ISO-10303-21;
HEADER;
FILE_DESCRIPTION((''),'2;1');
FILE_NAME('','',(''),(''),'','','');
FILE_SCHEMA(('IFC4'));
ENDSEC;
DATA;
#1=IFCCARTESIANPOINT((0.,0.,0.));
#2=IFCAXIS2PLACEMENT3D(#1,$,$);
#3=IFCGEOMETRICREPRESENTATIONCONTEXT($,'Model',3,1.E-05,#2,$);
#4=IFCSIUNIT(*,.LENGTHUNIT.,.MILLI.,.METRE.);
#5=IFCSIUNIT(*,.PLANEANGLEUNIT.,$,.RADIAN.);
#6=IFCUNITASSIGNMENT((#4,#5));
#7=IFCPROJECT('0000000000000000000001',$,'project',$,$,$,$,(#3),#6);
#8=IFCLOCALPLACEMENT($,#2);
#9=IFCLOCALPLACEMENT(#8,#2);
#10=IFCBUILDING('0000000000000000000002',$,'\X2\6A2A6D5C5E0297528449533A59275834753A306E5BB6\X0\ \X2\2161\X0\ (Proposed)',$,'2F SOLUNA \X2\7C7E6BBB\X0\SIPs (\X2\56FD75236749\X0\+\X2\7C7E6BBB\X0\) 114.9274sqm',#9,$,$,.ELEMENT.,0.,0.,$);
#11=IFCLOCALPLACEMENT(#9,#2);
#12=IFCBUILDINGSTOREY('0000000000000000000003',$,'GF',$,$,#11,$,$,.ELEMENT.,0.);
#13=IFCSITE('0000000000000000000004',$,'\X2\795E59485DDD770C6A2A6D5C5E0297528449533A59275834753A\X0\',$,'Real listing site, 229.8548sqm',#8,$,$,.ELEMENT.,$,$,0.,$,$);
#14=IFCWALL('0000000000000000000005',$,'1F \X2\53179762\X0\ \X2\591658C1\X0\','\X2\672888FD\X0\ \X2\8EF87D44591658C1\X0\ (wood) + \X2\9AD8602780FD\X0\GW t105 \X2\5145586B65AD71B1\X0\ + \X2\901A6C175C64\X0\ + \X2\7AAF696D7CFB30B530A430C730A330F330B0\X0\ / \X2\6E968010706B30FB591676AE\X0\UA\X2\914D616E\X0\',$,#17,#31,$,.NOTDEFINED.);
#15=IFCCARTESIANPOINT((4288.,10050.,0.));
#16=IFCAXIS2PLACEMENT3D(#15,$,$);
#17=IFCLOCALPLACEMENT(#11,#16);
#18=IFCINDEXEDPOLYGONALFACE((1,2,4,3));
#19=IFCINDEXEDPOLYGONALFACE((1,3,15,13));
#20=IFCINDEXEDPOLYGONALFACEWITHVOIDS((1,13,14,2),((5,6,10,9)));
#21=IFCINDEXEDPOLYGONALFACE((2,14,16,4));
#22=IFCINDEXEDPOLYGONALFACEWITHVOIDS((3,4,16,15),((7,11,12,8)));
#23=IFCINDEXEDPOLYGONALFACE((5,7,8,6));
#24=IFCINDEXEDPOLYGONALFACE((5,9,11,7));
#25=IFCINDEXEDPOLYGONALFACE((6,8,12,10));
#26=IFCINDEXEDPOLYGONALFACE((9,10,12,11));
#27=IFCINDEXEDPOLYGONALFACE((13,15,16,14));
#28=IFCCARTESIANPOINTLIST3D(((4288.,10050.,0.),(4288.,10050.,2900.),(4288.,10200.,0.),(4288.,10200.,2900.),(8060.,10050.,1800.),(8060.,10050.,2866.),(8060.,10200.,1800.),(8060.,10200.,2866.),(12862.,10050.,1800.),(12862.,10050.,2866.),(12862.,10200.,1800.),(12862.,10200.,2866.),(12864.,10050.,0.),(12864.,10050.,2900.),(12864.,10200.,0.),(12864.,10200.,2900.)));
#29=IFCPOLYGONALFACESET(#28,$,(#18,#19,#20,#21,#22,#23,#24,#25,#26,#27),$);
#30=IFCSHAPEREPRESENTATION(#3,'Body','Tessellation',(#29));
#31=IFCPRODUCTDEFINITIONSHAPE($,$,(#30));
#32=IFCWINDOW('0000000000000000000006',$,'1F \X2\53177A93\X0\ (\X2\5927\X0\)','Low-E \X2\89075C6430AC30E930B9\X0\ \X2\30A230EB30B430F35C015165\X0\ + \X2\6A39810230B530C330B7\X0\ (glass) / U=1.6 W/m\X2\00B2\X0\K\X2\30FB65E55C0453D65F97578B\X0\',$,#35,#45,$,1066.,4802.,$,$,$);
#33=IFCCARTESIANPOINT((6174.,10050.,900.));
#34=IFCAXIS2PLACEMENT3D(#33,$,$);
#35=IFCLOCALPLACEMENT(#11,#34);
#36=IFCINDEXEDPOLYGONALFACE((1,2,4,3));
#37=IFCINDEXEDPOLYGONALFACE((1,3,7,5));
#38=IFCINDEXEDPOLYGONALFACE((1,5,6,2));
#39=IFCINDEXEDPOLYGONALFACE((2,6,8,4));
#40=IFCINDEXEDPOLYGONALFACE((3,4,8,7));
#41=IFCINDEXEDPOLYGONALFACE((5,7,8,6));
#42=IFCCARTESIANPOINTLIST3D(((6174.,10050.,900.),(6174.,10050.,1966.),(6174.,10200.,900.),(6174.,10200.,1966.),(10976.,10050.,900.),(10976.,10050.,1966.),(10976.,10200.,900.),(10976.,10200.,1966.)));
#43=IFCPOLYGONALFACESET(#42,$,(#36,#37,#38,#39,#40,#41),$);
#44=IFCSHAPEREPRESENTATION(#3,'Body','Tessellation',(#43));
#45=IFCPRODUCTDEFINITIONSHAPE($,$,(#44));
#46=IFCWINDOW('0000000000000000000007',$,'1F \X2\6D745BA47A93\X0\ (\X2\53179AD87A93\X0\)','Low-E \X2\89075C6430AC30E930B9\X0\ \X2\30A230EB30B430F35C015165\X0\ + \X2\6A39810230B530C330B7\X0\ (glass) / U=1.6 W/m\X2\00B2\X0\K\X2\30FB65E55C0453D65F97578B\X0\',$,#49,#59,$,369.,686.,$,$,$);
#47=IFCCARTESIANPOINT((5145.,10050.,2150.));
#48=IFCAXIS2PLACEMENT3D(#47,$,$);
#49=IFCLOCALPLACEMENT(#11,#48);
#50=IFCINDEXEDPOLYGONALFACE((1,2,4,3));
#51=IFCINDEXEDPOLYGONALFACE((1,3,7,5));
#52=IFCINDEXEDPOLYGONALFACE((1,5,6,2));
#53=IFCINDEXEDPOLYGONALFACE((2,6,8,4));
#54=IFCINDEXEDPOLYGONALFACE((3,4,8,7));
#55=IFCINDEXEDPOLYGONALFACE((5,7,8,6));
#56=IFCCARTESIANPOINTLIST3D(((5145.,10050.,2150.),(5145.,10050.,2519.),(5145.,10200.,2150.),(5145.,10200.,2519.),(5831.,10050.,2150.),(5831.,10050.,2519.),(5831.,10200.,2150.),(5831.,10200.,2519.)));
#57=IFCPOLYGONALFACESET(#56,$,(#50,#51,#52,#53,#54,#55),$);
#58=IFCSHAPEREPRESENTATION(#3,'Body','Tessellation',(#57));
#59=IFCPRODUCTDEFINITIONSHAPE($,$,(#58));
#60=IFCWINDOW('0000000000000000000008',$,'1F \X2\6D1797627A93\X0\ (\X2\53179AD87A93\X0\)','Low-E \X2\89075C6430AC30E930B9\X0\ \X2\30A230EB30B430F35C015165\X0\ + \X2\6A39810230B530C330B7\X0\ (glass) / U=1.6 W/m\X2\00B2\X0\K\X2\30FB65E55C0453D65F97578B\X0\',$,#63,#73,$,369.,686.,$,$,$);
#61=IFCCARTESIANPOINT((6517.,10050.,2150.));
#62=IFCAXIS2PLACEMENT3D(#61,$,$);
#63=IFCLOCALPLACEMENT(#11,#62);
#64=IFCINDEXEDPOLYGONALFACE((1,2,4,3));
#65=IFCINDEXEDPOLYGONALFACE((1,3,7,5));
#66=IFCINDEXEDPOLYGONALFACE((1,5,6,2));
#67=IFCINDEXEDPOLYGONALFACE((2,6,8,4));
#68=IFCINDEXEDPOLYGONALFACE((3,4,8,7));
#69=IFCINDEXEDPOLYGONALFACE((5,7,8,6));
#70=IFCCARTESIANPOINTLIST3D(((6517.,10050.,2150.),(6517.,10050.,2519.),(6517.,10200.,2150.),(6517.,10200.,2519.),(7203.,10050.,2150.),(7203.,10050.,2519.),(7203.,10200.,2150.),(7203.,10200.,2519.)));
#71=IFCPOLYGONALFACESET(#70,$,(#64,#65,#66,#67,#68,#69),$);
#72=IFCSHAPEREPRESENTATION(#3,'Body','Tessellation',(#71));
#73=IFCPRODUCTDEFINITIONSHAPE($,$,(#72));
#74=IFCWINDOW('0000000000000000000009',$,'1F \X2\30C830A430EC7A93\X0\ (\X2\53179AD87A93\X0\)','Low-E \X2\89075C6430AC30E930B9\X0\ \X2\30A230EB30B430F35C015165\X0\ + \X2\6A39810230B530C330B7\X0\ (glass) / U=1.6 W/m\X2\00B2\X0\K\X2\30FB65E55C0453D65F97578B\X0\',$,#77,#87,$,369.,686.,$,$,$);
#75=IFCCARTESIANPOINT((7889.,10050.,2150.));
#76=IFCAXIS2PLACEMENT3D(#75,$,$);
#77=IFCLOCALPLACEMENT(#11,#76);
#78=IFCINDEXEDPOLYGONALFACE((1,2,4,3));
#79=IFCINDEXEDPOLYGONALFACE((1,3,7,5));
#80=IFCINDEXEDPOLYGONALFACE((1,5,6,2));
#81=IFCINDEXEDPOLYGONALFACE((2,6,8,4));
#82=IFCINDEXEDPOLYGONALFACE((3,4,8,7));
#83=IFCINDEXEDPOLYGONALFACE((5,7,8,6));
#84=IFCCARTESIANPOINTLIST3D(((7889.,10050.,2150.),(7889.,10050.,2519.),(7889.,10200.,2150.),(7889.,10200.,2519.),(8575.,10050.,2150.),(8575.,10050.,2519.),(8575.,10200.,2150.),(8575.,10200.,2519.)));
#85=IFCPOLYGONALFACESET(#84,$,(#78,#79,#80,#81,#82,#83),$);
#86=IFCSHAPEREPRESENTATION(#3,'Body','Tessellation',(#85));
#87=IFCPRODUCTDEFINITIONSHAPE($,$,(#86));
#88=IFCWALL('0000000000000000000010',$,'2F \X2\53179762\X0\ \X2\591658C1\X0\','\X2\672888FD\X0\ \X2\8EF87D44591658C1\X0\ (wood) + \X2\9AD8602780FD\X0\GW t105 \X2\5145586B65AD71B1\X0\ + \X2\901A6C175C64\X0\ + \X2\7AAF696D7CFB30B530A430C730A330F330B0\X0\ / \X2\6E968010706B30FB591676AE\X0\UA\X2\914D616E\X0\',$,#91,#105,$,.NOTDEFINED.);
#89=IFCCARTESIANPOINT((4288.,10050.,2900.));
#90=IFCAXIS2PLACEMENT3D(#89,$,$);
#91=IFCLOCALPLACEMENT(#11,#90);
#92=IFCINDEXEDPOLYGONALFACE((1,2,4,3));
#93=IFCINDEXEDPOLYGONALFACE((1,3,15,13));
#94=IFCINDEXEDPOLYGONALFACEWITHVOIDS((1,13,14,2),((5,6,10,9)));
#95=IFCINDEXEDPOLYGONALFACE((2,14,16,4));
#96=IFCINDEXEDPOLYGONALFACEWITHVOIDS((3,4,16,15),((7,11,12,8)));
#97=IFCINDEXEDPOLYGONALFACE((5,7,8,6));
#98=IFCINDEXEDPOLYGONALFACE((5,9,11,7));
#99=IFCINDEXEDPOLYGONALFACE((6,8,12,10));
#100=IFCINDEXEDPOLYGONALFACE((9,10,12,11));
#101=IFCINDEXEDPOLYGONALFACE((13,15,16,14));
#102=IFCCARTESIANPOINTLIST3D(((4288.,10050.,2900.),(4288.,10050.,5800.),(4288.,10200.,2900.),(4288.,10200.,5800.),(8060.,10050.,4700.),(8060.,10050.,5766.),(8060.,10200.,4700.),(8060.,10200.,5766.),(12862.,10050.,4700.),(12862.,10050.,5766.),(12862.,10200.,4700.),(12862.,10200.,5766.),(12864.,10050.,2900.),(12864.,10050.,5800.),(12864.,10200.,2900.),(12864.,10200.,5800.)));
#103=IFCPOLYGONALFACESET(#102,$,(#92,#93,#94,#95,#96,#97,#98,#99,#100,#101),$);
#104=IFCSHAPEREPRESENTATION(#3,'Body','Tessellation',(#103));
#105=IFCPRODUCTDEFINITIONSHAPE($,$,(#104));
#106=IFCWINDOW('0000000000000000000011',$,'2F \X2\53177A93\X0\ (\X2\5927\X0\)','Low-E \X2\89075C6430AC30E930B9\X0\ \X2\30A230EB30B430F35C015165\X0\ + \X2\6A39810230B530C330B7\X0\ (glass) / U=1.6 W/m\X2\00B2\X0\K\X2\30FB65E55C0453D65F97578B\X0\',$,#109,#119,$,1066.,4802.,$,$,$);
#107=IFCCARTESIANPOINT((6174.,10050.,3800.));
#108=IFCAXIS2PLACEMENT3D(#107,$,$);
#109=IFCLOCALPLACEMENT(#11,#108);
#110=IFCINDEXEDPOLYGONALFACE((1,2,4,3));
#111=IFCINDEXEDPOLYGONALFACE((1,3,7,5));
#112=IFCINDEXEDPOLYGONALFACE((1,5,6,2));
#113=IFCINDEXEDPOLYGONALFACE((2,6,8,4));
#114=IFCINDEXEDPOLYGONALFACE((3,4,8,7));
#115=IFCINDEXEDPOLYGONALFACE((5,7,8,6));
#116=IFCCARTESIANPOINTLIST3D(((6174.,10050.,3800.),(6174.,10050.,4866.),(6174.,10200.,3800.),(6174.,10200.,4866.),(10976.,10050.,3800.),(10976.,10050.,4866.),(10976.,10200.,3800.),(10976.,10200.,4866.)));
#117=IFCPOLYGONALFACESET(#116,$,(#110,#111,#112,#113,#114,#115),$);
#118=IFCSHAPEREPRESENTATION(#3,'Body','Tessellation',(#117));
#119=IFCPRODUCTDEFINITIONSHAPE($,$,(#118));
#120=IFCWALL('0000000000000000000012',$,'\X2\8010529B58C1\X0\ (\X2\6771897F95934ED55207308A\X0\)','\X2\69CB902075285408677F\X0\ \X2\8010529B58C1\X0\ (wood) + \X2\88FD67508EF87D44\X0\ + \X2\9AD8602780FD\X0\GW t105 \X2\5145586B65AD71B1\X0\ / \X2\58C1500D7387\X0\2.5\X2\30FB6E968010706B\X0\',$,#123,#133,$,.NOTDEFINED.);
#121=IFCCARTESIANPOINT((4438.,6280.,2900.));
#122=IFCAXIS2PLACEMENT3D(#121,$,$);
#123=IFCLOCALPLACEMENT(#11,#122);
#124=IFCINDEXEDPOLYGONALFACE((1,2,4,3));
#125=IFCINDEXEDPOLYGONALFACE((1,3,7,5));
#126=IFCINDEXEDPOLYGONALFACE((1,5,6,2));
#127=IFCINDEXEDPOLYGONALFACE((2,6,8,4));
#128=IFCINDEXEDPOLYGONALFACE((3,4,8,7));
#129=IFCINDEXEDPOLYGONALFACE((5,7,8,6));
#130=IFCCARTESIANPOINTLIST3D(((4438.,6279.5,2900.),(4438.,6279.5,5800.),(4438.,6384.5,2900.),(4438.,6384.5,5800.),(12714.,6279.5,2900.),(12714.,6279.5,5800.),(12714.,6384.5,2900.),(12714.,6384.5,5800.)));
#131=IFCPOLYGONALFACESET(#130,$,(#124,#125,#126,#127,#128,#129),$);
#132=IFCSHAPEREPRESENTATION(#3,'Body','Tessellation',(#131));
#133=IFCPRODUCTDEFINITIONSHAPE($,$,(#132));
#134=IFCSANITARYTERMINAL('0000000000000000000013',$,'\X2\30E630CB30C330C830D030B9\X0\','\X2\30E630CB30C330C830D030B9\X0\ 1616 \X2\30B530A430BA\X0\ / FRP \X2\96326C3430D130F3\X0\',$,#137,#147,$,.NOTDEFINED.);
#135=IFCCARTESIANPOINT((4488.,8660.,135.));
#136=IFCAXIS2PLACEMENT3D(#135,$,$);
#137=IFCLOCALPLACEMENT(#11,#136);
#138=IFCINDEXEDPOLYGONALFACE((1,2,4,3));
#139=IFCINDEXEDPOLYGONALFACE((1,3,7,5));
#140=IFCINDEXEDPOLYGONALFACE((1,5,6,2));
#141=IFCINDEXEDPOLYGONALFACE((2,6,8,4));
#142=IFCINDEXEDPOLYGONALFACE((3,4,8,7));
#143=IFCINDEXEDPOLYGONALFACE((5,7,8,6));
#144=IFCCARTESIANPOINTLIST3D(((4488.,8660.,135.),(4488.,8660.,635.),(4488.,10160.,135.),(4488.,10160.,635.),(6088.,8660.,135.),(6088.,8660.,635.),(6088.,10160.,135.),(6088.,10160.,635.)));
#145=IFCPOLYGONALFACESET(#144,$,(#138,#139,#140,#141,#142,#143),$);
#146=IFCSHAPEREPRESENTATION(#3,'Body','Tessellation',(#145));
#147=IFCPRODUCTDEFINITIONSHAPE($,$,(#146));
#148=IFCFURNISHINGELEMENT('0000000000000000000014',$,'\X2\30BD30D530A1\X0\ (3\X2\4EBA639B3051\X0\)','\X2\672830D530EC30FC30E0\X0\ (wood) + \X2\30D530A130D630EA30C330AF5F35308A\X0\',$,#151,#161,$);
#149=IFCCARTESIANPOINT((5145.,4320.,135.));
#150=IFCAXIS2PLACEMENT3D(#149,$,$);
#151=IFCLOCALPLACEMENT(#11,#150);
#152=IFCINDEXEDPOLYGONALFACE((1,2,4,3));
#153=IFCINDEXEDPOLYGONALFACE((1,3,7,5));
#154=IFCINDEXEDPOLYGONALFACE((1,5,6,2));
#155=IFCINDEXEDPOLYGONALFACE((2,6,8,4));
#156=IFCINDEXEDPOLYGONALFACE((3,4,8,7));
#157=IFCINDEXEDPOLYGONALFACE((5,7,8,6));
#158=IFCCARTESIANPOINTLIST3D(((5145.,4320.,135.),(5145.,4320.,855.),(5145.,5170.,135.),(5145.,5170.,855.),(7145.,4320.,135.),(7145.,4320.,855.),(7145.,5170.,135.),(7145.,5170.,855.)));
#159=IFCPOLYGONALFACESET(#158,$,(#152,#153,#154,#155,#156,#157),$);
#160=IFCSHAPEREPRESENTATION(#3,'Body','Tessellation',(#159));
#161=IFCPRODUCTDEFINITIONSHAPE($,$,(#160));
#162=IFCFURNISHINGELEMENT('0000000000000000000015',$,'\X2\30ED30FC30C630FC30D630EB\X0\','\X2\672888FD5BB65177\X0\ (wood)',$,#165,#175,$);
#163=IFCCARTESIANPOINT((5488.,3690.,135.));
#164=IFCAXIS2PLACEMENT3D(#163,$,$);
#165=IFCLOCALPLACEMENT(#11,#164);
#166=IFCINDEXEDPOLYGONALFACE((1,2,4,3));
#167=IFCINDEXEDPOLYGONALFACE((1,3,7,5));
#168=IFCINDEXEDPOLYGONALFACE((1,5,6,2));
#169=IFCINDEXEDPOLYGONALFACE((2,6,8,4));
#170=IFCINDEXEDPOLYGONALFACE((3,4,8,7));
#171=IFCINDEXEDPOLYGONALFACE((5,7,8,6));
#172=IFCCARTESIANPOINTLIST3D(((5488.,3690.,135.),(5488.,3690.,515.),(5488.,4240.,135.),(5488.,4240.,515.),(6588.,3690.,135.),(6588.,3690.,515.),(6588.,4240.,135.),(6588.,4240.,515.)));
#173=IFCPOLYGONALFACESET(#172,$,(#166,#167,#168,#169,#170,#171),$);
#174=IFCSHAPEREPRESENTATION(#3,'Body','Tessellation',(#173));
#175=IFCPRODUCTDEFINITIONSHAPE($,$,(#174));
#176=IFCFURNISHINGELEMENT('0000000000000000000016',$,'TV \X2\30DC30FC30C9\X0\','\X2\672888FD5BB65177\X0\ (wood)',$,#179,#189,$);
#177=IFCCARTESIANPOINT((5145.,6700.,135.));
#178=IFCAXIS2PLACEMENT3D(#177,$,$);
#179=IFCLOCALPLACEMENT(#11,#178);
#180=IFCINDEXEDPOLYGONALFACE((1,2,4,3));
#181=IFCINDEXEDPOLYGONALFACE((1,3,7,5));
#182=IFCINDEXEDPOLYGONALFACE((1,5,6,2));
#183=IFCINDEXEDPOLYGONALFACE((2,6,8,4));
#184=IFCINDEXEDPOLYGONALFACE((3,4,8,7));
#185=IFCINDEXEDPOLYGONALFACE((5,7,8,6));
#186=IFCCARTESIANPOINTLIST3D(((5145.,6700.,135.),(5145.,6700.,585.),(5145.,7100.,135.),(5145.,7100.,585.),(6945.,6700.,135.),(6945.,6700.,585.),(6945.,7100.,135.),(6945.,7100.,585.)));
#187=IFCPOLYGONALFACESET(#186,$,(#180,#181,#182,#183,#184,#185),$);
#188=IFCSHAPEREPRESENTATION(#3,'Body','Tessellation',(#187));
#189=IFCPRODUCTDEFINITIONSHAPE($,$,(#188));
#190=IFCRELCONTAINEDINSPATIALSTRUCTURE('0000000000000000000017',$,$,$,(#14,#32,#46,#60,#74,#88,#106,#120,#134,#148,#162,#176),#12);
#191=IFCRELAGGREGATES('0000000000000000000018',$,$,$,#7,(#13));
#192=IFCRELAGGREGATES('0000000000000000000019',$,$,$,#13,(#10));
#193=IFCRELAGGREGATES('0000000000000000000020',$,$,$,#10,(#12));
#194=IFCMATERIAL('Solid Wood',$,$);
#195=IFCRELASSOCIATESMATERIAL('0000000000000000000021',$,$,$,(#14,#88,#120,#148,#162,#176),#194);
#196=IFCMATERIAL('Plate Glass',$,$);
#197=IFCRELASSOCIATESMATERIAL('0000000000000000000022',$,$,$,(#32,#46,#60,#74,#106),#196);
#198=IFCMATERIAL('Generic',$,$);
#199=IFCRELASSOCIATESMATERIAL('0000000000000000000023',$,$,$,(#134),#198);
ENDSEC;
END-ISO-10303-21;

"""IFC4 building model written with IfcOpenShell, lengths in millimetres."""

from ifc_helpers import new_model, si_unit, frame, frame_2d, origin, place, context, project, spatial, rectangle, extrude, material, element, fill, save


model = new_model("IFC4")

# Units and contexts
model_context = context("Model", 3, precision=1e-05, world=origin())
ifc_project = project(units=[si_unit("LENGTHUNIT", "METRE", prefix="MILLI"), si_unit("PLANEANGLEUNIT", "RADIAN")], contexts=[model_context])

# Site, building, storey
site_placement = place(None, origin())
site = spatial("IfcSite", under=ifc_project, at=site_placement, Name="神奈川県横浜市青葉区大場町", ObjectType="Real listing site, 229.8548sqm", CompositionType="ELEMENT", RefElevation=0.0)
building_placement = place(site_placement, origin())
building = spatial("IfcBuilding", under=site, at=building_placement, Name="横浜市青葉区大場町の家 Ⅱ (Proposed)", ObjectType="2F SOLUNA 籾殻SIPs (国産杉+籾殻) 114.9274sqm", CompositionType="ELEMENT", ElevationOfRefHeight=0.0, ElevationOfTerrain=0.0)
storey_placement = place(building_placement, origin())
storey = spatial("IfcBuildingStorey", under=building, at=storey_placement, Name="GF", CompositionType="ELEMENT", Elevation=0.0)

# Wall, openings, windows
ifc_material_1 = material(Name="Solid Wood")
wall_1_placement = place(storey_placement, frame((4288.0, 10050.0, 0.0)))
wall_1 = element("IfcWall", 1, at=wall_1_placement, inside=storey, material=ifc_material_1, Name="1F 北面 外壁", Description="木製 軸組外壁 (wood) + 高性能GW t105 充填断熱 + 通気層 + 窯業系サイディング / 準耐火・外皮UA配慮", PredefinedType="NOTDEFINED", context=model_context, shape_type="SweptSolid", body=[
    extrude(rectangle(XDim=8576.0, YDim=150.0, at=frame_2d((4288.0, 75.0))), frame((4288.0, 10050.0, 0.0)), (0.0, 0.0, 1.0), 2900.0),
])
opening_1_placement = place(storey_placement, frame((6174.0, 10050.0, 900.0)))
opening_1 = element("IfcOpeningElement", 2, at=opening_1_placement, cuts=wall_1, PredefinedType="NOTDEFINED", context=model_context, shape_type="SweptSolid", body=[
    extrude(rectangle(XDim=4802.0, YDim=150.0, at=frame_2d((2401.0, 75.0))), frame((6174.0, 10050.0, 900.0)), (0.0, 0.0, 1.0), 1066.0),
])
opening_2_placement = place(storey_placement, frame((5145.0, 10050.0, 2150.0)))
opening_2 = element("IfcOpeningElement", 3, at=opening_2_placement, cuts=wall_1, PredefinedType="NOTDEFINED", context=model_context, shape_type="SweptSolid", body=[
    extrude(rectangle(XDim=686.0, YDim=150.0, at=frame_2d((343.0, 75.0))), frame((5145.0, 10050.0, 2150.0)), (0.0, 0.0, 1.0), 369.0),
])
opening_3_placement = place(storey_placement, frame((6517.0, 10050.0, 2150.0)))
opening_3 = element("IfcOpeningElement", 4, at=opening_3_placement, cuts=wall_1, PredefinedType="NOTDEFINED", context=model_context, shape_type="SweptSolid", body=[
    extrude(rectangle(XDim=686.0, YDim=150.0, at=frame_2d((343.0, 75.0))), frame((6517.0, 10050.0, 2150.0)), (0.0, 0.0, 1.0), 369.0),
])
opening_4_placement = place(storey_placement, frame((7889.0, 10050.0, 2150.0)))
opening_4 = element("IfcOpeningElement", 5, at=opening_4_placement, cuts=wall_1, PredefinedType="NOTDEFINED", context=model_context, shape_type="SweptSolid", body=[
    extrude(rectangle(XDim=686.0, YDim=150.0, at=frame_2d((343.0, 75.0))), frame((7889.0, 10050.0, 2150.0)), (0.0, 0.0, 1.0), 369.0),
])
ifc_material_2 = material(Name="Plate Glass")
window_1_placement = place(storey_placement, frame((6174.0, 10050.0, 900.0)))
window_1 = element("IfcWindow", 6, at=window_1_placement, inside=storey, material=ifc_material_2, Name="1F 北窓 (大)", Description="Low-E 複層ガラス アルゴン封入 + 樹脂サッシ (glass) / U=1.6 W/m²K・日射取得型", OverallHeight=1066.0, OverallWidth=4802.0, context=model_context, shape_type="SweptSolid", body=[
    extrude(rectangle(XDim=4802.0, YDim=150.0, at=frame_2d((2401.0, 75.0))), frame((6174.0, 10050.0, 900.0)), (0.0, 0.0, 1.0), 1066.0),
])
fill(opening_1, window_1)
window_2_placement = place(storey_placement, frame((5145.0, 10050.0, 2150.0)))
window_2 = element("IfcWindow", 7, at=window_2_placement, inside=storey, material=ifc_material_2, Name="1F 浴室窓 (北高窓)", Description="Low-E 複層ガラス アルゴン封入 + 樹脂サッシ (glass) / U=1.6 W/m²K・日射取得型", OverallHeight=369.0, OverallWidth=686.0, context=model_context, shape_type="SweptSolid", body=[
    extrude(rectangle(XDim=686.0, YDim=150.0, at=frame_2d((343.0, 75.0))), frame((5145.0, 10050.0, 2150.0)), (0.0, 0.0, 1.0), 369.0),
])
fill(opening_2, window_2)
window_3_placement = place(storey_placement, frame((6517.0, 10050.0, 2150.0)))
window_3 = element("IfcWindow", 8, at=window_3_placement, inside=storey, material=ifc_material_2, Name="1F 洗面窓 (北高窓)", Description="Low-E 複層ガラス アルゴン封入 + 樹脂サッシ (glass) / U=1.6 W/m²K・日射取得型", OverallHeight=369.0, OverallWidth=686.0, context=model_context, shape_type="SweptSolid", body=[
    extrude(rectangle(XDim=686.0, YDim=150.0, at=frame_2d((343.0, 75.0))), frame((6517.0, 10050.0, 2150.0)), (0.0, 0.0, 1.0), 369.0),
])
fill(opening_3, window_3)
window_4_placement = place(storey_placement, frame((7889.0, 10050.0, 2150.0)))
window_4 = element("IfcWindow", 9, at=window_4_placement, inside=storey, material=ifc_material_2, Name="1F トイレ窓 (北高窓)", Description="Low-E 複層ガラス アルゴン封入 + 樹脂サッシ (glass) / U=1.6 W/m²K・日射取得型", OverallHeight=369.0, OverallWidth=686.0, context=model_context, shape_type="SweptSolid", body=[
    extrude(rectangle(XDim=686.0, YDim=150.0, at=frame_2d((343.0, 75.0))), frame((7889.0, 10050.0, 2150.0)), (0.0, 0.0, 1.0), 369.0),
])
fill(opening_4, window_4)

# Wall, opening, window
wall_2_placement = place(storey_placement, frame((4288.0, 10050.0, 2900.0)))
wall_2 = element("IfcWall", 10, at=wall_2_placement, inside=storey, material=ifc_material_1, Name="2F 北面 外壁", Description="木製 軸組外壁 (wood) + 高性能GW t105 充填断熱 + 通気層 + 窯業系サイディング / 準耐火・外皮UA配慮", PredefinedType="NOTDEFINED", context=model_context, shape_type="SweptSolid", body=[
    extrude(rectangle(XDim=8576.0, YDim=150.0, at=frame_2d((4288.0, 75.0))), frame((4288.0, 10050.0, 2900.0)), (0.0, 0.0, 1.0), 2900.0),
])
opening_5_placement = place(storey_placement, frame((6174.0, 10050.0, 3800.0)))
opening_5 = element("IfcOpeningElement", 11, at=opening_5_placement, cuts=wall_2, PredefinedType="NOTDEFINED", context=model_context, shape_type="SweptSolid", body=[
    extrude(rectangle(XDim=4802.0, YDim=150.0, at=frame_2d((2401.0, 75.0))), frame((6174.0, 10050.0, 3800.0)), (0.0, 0.0, 1.0), 1066.0),
])
window_5_placement = place(storey_placement, frame((6174.0, 10050.0, 3800.0)))
window_5 = element("IfcWindow", 12, at=window_5_placement, inside=storey, material=ifc_material_2, Name="2F 北窓 (大)", Description="Low-E 複層ガラス アルゴン封入 + 樹脂サッシ (glass) / U=1.6 W/m²K・日射取得型", OverallHeight=1066.0, OverallWidth=4802.0, context=model_context, shape_type="SweptSolid", body=[
    extrude(rectangle(XDim=4802.0, YDim=150.0, at=frame_2d((2401.0, 75.0))), frame((6174.0, 10050.0, 3800.0)), (0.0, 0.0, 1.0), 1066.0),
])
fill(opening_5, window_5)

# Wall
wall_3_placement = place(storey_placement, frame((4438.0, 6280.0, 2900.0)))
element("IfcWall", 13, at=wall_3_placement, inside=storey, material=ifc_material_1, Name="耐力壁 (東西間仕切り)", Description="構造用合板 耐力壁 (wood) + 製材軸組 + 高性能GW t105 充填断熱 / 壁倍率2.5・準耐火", PredefinedType="NOTDEFINED", context=model_context, shape_type="SweptSolid", body=[
    extrude(rectangle(XDim=8276.0, YDim=105.0, at=frame_2d((4138.0, 52.0))), frame((4438.0, 6280.0, 2900.0)), (0.0, 0.0, 1.0), 2900.0),
])

# Sanitary terminal
ifc_material_3 = material(Name="Generic")
sanitary_terminal_placement = place(storey_placement, frame((4488.0, 8660.0, 135.0)))
element("IfcSanitaryTerminal", 14, at=sanitary_terminal_placement, inside=storey, material=ifc_material_3, Name="ユニットバス", Description="ユニットバス 1616 サイズ / FRP 防水パン", PredefinedType="NOTDEFINED", context=model_context, shape_type="SweptSolid", body=[
    extrude(rectangle(XDim=1600.0, YDim=1500.0, at=frame_2d((800.0, 750.0))), frame((4488.0, 8660.0, 135.0)), (0.0, 0.0, 1.0), 500.0),
])

# Furnishing elements
furnishing_1_placement = place(storey_placement, frame((5145.0, 4320.0, 135.0)))
element("IfcFurnishingElement", 15, at=furnishing_1_placement, inside=storey, material=ifc_material_1, Name="ソファ (3人掛け)", Description="木フレーム (wood) + ファブリック張り", context=model_context, shape_type="SweptSolid", body=[
    extrude(rectangle(XDim=2000.0, YDim=850.0, at=frame_2d((1000.0, 425.0))), frame((5145.0, 4320.0, 135.0)), (0.0, 0.0, 1.0), 720.0),
])
furnishing_2_placement = place(storey_placement, frame((5488.0, 3690.0, 135.0)))
element("IfcFurnishingElement", 16, at=furnishing_2_placement, inside=storey, material=ifc_material_1, Name="ローテーブル", Description="木製家具 (wood)", context=model_context, shape_type="SweptSolid", body=[
    extrude(rectangle(XDim=1100.0, YDim=550.0, at=frame_2d((550.0, 275.0))), frame((5488.0, 3690.0, 135.0)), (0.0, 0.0, 1.0), 380.0),
])
furnishing_3_placement = place(storey_placement, frame((5145.0, 6700.0, 135.0)))
element("IfcFurnishingElement", 17, at=furnishing_3_placement, inside=storey, material=ifc_material_1, Name="TV ボード", Description="木製家具 (wood)", context=model_context, shape_type="SweptSolid", body=[
    extrude(rectangle(XDim=1800.0, YDim=400.0, at=frame_2d((900.0, 200.0))), frame((5145.0, 6700.0, 135.0)), (0.0, 0.0, 1.0), 450.0),
])

save(model, "model.ifc")
